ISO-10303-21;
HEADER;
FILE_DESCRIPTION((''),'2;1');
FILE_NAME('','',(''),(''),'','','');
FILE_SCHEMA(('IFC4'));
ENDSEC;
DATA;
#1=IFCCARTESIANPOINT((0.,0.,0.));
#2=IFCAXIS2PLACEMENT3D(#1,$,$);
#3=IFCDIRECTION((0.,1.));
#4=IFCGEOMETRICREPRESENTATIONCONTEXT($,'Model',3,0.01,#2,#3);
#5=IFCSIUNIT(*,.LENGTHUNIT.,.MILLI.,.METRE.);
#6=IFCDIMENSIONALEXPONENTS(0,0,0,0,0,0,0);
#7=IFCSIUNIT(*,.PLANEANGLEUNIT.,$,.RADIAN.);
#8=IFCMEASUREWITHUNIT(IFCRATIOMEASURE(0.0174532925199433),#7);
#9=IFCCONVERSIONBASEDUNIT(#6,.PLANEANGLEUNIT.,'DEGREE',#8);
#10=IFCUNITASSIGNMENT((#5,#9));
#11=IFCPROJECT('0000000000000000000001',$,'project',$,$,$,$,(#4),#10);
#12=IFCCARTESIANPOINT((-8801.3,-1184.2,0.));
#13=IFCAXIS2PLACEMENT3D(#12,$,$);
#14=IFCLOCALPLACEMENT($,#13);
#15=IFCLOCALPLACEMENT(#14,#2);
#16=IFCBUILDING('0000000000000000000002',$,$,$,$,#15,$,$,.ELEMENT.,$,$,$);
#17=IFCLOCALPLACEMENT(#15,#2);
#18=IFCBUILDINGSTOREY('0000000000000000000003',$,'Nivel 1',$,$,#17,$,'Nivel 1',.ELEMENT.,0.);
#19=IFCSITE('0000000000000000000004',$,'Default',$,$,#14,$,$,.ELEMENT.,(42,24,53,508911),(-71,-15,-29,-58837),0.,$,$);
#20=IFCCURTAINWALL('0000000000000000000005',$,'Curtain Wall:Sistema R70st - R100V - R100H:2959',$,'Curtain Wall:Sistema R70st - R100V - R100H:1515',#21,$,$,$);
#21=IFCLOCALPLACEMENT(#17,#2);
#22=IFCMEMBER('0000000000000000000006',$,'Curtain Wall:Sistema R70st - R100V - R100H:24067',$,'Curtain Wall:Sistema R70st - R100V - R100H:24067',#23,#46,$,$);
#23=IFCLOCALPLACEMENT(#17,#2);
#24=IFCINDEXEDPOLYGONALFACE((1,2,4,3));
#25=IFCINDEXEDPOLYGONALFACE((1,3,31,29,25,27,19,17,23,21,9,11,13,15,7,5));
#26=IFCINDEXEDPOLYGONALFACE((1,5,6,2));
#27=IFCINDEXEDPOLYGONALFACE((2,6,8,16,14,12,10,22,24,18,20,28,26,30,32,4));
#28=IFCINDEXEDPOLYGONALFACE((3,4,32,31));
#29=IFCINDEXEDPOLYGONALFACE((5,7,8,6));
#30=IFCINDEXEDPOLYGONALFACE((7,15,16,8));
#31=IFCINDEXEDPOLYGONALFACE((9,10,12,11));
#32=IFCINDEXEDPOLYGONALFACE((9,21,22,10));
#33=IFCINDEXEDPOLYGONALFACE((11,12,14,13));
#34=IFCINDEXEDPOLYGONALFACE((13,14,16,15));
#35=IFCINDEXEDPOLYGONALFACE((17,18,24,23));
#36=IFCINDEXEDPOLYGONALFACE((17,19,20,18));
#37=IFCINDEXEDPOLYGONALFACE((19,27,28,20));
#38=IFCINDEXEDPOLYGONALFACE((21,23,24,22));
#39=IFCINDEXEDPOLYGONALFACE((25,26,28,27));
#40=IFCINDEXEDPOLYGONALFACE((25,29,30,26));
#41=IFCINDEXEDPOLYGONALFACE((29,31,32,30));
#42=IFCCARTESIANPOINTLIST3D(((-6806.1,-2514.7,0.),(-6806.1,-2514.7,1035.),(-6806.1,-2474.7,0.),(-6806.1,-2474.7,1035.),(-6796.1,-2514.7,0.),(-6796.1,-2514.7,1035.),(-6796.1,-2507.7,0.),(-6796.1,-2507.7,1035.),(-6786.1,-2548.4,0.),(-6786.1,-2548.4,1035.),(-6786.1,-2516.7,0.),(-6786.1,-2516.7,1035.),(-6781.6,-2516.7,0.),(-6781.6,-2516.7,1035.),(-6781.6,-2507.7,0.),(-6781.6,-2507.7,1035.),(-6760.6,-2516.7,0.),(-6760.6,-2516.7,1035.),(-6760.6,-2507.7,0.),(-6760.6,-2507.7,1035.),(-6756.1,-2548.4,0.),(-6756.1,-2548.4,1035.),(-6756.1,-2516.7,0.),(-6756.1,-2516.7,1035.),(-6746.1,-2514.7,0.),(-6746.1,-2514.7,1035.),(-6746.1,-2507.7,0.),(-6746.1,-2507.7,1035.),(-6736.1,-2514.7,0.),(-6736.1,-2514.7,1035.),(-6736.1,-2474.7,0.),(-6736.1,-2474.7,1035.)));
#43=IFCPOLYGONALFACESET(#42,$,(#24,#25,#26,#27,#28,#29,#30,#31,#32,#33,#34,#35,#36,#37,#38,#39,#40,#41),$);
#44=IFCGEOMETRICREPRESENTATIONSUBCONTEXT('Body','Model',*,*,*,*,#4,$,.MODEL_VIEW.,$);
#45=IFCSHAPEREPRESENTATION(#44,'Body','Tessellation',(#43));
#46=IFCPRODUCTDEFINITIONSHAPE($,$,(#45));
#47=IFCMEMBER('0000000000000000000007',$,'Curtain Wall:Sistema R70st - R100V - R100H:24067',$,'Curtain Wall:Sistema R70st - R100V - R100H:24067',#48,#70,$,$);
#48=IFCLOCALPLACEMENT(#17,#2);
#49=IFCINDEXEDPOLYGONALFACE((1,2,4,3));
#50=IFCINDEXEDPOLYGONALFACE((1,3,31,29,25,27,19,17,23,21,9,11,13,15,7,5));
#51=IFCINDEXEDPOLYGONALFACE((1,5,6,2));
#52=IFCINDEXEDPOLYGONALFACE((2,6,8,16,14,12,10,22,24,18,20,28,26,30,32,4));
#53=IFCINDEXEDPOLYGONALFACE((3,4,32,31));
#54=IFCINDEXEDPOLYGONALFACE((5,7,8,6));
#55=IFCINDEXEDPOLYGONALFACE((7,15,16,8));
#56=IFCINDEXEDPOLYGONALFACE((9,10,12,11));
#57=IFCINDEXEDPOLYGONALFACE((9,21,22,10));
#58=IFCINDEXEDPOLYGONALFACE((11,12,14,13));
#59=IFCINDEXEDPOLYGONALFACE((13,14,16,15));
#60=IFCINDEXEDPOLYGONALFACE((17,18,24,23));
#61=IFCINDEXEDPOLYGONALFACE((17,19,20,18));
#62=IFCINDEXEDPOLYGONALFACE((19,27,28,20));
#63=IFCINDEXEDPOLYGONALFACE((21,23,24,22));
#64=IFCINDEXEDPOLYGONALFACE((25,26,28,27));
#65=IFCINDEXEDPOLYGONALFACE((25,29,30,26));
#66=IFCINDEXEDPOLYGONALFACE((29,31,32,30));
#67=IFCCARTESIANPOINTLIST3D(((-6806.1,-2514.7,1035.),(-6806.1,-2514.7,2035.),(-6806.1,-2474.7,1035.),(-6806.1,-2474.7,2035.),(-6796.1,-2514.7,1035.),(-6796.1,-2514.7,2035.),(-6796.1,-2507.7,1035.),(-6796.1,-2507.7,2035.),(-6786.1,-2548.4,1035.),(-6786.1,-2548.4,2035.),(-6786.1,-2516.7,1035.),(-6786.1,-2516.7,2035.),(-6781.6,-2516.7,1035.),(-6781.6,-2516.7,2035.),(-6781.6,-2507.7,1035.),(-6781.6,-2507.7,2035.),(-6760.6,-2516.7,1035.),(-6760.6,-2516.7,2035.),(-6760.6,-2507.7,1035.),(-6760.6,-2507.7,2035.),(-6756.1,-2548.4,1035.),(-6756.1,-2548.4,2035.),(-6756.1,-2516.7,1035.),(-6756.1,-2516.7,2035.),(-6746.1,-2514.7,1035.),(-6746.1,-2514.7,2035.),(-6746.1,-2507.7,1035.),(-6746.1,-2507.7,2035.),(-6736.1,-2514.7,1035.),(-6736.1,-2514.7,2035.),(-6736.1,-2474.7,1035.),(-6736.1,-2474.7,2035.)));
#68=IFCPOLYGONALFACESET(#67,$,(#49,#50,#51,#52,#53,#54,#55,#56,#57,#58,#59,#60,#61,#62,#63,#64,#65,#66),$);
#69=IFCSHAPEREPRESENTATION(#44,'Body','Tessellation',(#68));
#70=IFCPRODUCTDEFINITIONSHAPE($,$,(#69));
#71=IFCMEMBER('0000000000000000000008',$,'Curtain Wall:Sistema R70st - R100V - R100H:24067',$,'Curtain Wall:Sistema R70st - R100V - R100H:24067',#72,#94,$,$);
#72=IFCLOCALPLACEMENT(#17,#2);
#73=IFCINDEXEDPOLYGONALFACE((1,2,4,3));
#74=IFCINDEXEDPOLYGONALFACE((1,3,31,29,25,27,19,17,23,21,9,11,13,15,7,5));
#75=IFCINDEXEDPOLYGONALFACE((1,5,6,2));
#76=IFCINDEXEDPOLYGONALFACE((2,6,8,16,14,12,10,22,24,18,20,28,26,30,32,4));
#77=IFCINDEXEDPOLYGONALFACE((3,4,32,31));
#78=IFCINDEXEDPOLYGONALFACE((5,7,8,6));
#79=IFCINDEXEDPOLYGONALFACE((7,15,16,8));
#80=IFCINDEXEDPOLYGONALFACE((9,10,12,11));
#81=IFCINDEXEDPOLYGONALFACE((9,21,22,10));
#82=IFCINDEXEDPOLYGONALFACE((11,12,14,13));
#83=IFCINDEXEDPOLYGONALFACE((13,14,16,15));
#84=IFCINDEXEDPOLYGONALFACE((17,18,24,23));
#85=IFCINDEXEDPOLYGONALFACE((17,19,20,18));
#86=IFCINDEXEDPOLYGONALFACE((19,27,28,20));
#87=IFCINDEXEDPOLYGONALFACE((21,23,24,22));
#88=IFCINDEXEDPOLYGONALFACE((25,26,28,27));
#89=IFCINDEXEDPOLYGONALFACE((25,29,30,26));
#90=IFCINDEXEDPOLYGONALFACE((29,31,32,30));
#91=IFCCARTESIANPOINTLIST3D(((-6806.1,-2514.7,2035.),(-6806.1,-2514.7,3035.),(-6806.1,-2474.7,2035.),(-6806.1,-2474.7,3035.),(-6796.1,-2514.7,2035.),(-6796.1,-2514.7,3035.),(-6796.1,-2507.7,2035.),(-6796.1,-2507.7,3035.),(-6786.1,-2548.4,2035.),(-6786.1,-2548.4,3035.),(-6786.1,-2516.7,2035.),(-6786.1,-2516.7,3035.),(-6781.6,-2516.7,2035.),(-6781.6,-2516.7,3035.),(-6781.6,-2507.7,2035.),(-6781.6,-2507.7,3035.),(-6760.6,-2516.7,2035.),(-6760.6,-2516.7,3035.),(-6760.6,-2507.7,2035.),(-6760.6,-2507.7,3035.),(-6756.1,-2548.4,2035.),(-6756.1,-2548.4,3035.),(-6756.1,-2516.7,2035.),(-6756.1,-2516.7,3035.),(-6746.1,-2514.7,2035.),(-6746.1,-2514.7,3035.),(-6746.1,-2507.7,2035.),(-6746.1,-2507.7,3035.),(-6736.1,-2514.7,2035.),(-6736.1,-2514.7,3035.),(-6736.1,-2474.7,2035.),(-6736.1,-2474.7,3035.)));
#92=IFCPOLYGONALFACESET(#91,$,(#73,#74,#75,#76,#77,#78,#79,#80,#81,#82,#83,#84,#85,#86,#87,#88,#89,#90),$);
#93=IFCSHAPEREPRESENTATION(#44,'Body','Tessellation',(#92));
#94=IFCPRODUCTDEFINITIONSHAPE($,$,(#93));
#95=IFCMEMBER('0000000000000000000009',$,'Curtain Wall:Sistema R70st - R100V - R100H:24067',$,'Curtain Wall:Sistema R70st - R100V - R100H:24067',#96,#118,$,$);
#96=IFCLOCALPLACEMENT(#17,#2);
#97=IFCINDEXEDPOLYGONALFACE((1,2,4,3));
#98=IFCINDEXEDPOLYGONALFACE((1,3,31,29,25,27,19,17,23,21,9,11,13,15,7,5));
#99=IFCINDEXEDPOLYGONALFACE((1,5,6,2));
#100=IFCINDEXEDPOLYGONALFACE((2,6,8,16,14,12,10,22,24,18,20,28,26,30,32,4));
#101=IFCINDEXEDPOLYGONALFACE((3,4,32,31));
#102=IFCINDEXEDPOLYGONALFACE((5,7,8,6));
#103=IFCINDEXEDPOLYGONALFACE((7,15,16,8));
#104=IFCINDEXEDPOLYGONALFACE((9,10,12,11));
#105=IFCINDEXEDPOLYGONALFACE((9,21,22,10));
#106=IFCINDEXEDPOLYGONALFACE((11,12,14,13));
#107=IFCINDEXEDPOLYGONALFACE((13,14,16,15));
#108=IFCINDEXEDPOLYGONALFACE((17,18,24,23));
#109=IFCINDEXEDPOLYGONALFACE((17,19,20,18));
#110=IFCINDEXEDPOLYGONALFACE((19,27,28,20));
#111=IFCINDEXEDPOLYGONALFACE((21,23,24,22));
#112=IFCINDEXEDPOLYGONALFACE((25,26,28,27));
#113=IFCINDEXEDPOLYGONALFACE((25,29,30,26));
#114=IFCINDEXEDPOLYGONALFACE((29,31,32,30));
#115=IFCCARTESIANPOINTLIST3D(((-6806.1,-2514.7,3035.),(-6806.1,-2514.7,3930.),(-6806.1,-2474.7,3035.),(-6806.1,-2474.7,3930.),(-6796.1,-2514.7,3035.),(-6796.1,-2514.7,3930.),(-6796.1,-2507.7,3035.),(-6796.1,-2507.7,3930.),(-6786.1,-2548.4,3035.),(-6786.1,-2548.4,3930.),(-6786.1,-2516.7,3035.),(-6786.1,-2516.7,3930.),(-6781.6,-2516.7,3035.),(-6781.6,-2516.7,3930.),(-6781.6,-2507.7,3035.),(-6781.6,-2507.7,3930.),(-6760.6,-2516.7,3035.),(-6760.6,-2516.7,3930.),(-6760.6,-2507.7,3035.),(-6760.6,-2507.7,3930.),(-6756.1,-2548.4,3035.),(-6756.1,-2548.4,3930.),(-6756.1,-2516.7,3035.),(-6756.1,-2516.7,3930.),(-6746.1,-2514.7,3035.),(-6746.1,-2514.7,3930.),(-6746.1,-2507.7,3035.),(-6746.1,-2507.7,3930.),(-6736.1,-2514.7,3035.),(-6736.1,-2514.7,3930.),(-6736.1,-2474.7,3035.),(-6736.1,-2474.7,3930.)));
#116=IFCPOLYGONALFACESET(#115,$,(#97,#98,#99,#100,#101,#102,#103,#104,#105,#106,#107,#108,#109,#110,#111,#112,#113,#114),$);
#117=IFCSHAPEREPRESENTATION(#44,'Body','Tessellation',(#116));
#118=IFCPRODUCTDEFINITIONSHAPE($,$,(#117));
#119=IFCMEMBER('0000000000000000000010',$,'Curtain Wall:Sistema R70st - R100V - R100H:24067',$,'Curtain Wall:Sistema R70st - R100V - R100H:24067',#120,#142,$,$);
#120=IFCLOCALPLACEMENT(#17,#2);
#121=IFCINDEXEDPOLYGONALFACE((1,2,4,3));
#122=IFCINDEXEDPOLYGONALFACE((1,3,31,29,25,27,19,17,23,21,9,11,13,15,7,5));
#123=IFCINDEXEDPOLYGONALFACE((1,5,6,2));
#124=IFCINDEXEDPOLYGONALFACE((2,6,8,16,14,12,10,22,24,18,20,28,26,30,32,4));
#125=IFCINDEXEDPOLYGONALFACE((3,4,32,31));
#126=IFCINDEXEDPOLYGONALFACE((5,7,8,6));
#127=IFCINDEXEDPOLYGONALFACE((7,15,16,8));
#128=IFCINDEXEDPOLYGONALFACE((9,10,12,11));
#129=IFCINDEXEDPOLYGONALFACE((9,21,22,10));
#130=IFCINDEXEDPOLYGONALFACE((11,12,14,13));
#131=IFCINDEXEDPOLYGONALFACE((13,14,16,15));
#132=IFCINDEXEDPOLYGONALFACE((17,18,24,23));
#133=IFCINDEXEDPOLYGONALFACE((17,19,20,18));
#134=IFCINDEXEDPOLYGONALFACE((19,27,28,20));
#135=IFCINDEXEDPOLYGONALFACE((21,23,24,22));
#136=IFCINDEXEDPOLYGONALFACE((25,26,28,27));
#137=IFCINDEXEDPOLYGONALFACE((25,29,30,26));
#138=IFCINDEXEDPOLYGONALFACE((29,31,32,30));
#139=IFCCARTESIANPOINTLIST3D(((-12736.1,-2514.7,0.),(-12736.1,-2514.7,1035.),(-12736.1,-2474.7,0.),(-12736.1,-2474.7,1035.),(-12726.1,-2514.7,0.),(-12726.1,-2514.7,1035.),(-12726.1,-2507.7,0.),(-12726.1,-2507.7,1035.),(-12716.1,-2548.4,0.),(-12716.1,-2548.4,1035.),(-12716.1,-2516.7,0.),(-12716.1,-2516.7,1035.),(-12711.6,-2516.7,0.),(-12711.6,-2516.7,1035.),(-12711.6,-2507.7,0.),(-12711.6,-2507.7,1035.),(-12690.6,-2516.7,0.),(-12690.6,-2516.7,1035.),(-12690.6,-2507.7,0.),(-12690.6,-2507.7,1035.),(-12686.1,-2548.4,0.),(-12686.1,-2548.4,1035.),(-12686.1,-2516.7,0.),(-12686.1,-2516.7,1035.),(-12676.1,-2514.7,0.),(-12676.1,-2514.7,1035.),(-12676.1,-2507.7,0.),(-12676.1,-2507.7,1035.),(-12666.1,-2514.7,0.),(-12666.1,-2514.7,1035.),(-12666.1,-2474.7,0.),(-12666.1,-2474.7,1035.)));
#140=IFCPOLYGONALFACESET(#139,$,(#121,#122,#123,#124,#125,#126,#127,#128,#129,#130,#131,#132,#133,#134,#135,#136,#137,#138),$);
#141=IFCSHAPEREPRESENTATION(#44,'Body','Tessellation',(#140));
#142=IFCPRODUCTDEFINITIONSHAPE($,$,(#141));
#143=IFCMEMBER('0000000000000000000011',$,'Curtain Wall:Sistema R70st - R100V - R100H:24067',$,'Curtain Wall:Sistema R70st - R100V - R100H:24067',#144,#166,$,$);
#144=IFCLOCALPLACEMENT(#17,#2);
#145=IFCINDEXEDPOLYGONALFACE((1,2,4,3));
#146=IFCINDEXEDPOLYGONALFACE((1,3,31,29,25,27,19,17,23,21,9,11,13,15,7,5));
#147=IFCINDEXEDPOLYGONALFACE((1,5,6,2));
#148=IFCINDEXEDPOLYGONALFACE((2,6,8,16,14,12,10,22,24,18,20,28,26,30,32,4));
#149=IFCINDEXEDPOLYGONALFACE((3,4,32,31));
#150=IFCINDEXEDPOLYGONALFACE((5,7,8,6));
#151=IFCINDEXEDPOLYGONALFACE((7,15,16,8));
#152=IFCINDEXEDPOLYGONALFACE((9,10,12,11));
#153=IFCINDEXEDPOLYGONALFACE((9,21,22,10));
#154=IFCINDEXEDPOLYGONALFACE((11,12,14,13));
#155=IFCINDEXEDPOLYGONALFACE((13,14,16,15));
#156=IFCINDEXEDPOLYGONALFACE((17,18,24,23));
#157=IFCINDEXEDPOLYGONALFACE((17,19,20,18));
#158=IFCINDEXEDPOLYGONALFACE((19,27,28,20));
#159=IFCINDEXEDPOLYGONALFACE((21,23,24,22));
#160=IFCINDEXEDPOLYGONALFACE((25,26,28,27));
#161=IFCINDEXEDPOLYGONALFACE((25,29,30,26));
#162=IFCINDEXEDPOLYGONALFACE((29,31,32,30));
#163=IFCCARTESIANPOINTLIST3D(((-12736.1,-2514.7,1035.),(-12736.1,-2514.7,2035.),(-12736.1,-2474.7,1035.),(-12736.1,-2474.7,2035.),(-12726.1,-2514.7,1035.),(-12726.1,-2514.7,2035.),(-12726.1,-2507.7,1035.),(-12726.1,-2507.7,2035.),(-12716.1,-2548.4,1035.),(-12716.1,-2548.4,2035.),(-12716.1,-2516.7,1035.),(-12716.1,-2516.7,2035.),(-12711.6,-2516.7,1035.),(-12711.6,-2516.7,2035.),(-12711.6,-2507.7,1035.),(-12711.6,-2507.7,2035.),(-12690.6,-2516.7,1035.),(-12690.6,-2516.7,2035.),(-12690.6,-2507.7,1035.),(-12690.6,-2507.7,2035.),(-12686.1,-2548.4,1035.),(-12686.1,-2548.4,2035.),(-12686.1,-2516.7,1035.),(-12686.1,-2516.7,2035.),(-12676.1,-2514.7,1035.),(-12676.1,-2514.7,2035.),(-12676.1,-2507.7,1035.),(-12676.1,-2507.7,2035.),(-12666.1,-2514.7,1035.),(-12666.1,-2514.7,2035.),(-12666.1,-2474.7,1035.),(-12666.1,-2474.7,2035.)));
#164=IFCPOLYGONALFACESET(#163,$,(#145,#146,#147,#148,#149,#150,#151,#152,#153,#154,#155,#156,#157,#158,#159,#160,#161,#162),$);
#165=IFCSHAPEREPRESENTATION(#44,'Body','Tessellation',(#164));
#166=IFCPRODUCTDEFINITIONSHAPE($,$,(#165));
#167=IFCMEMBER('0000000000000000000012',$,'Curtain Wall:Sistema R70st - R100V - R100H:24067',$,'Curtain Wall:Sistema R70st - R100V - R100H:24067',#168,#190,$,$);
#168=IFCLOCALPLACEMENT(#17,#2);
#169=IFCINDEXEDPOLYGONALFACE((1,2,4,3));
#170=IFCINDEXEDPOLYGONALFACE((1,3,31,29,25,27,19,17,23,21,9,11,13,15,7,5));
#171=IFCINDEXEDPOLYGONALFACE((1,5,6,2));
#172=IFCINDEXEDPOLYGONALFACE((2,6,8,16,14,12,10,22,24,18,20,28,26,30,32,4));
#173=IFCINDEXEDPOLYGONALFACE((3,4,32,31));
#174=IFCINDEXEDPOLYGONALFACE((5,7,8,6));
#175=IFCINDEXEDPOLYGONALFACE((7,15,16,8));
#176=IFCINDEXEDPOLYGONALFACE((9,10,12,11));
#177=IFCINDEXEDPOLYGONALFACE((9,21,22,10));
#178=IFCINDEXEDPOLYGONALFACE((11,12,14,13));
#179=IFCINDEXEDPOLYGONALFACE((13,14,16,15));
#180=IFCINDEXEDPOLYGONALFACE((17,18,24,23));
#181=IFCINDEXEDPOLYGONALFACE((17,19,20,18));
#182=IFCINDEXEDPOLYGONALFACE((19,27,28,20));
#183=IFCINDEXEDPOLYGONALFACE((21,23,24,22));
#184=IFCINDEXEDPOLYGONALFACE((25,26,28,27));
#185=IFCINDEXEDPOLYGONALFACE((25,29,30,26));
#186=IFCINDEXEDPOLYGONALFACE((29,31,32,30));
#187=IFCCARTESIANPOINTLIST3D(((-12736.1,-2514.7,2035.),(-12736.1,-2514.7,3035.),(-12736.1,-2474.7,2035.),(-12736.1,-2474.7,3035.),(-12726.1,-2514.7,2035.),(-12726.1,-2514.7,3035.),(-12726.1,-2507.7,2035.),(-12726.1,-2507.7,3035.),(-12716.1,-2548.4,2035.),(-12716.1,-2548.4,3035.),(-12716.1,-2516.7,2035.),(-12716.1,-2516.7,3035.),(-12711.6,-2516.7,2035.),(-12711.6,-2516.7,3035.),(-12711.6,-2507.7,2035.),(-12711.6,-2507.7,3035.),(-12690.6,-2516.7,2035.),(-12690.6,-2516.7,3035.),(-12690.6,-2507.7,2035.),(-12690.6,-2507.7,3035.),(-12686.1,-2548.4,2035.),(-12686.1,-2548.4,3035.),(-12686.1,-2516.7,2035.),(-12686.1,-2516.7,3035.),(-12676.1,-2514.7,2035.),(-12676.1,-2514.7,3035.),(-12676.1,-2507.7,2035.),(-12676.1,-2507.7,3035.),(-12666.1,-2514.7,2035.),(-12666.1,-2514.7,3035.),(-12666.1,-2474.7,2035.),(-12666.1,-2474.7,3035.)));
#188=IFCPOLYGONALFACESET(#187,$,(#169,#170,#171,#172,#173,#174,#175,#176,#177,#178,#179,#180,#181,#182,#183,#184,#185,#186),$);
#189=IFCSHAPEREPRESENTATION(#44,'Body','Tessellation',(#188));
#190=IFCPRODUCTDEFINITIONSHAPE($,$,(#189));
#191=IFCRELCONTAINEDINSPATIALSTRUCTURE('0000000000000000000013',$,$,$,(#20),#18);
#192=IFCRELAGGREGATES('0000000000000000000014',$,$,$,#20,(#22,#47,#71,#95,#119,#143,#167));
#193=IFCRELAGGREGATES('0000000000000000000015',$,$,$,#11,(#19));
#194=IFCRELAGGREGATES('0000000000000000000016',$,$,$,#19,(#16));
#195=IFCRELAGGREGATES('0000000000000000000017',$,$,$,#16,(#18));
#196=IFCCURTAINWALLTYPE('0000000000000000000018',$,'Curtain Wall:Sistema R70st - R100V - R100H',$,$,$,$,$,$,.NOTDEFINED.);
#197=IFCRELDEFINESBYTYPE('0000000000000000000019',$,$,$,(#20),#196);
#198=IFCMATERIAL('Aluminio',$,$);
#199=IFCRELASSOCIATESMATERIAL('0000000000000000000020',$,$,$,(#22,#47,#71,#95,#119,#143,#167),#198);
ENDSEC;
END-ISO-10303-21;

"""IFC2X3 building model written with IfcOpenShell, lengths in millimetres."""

from ifc_helpers import new_model, entity, si_unit, converted_unit, direction, frame, origin, place, context, subcontext, project, spatial, polyline, outline, extrude, material, type_object, element, aggregate, save


model = new_model("IFC2X3")

# Units and contexts
model_context = context("Model", 3, precision=0.01, world=origin(), true_north=direction((0.0, 1.0)))
body_context = subcontext(model_context, "Body", "Model", "MODEL_VIEW")
ifc_project = project(units=[si_unit("LENGTHUNIT", "METRE", prefix="MILLI"), converted_unit("PLANEANGLEUNIT", "DEGREE", entity("IfcRatioMeasure", 0.0174532925199433), si_unit("PLANEANGLEUNIT", "RADIAN"), dimensions=[0, 0, 0, 0, 0, 0, 0])], contexts=[model_context])

# Site, building, storey
site_placement = place(None, frame((-8801.3, -1184.2, 0.0)))
site = spatial("IfcSite", under=ifc_project, at=site_placement, Name="Default", CompositionType="ELEMENT", RefLatitude=(42, 24, 53, 508911), RefLongitude=(-71, -15, -29, -58837), RefElevation=0.0)
building_placement = place(site_placement, origin())
building = spatial("IfcBuilding", under=site, at=building_placement, CompositionType="ELEMENT")
storey_placement = place(building_placement, origin())
storey = spatial("IfcBuildingStorey", under=building, at=storey_placement, Name="Nivel 1", LongName="Nivel 1", CompositionType="ELEMENT", Elevation=0.0)

# Curtain wall, members
curtain_wall_type = type_object("IfcCurtainWallType", Name="Curtain Wall:Sistema R70st - R100V - R100H", PredefinedType="NOTDEFINED")
curtain_wall_placement = place(storey_placement, origin())
curtain_wall = element("IfcCurtainWall", 1, at=curtain_wall_placement, inside=storey, type_object=curtain_wall_type, Name="Curtain Wall:Sistema R70st - R100V - R100H:2959", ObjectType="Curtain Wall:Sistema R70st - R100V - R100H:1515")
ifc_material = material(Name="Aluminio")
member_1_placement = place(curtain_wall_placement, origin())
member_1 = element("IfcMember", 2, at=member_1_placement, material=ifc_material, Name="Curtain Wall:Sistema R70st - R100V - R100H:24067", ObjectType="Curtain Wall:Sistema R70st - R100V - R100H:24067", context=body_context, shape_type="SweptSolid", body=[
    extrude(outline(polyline([(-35.0, -38.0), (35.0, -38.0), (35.0, 2.0), (25.0, 2.0), (25.0, -5.0), (10.5, -5.0), (10.5, 4.0), (15.0, 4.0), (15.0, 35.7), (-15.0, 35.7), (-15.0, 4.0), (-10.5, 4.0), (-10.5, -5.0), (-25.0, -5.0), (-25.0, 2.0), (-35.0, 2.0), (-35.0, -38.0)])), frame((-6771.1, -2512.7, 0.0), z_axis=(0.0, 0.0, 1.0), x_axis=(-1.0, 0.0, 0.0)), (0.0, 0.0, 1.0), 1035.0),
])
member_2_placement = place(curtain_wall_placement, origin())
member_2 = element("IfcMember", 3, at=member_2_placement, material=ifc_material, Name="Curtain Wall:Sistema R70st - R100V - R100H:24067", ObjectType="Curtain Wall:Sistema R70st - R100V - R100H:24067", context=body_context, shape_type="SweptSolid", body=[
    extrude(outline(polyline([(-35.0, -38.0), (35.0, -38.0), (35.0, 2.0), (25.0, 2.0), (25.0, -5.0), (10.5, -5.0), (10.5, 4.0), (15.0, 4.0), (15.0, 35.7), (-15.0, 35.7), (-15.0, 4.0), (-10.5, 4.0), (-10.5, -5.0), (-25.0, -5.0), (-25.0, 2.0), (-35.0, 2.0), (-35.0, -38.0)])), frame((-6771.1, -2512.7, 1035.0), z_axis=(0.0, 0.0, 1.0), x_axis=(-1.0, 0.0, 0.0)), (0.0, 0.0, 1.0), 1000.0),
])
member_3_placement = place(curtain_wall_placement, origin())
member_3 = element("IfcMember", 4, at=member_3_placement, material=ifc_material, Name="Curtain Wall:Sistema R70st - R100V - R100H:24067", ObjectType="Curtain Wall:Sistema R70st - R100V - R100H:24067", context=body_context, shape_type="SweptSolid", body=[
    extrude(outline(polyline([(-35.0, -38.0), (35.0, -38.0), (35.0, 2.0), (25.0, 2.0), (25.0, -5.0), (10.5, -5.0), (10.5, 4.0), (15.0, 4.0), (15.0, 35.7), (-15.0, 35.7), (-15.0, 4.0), (-10.5, 4.0), (-10.5, -5.0), (-25.0, -5.0), (-25.0, 2.0), (-35.0, 2.0), (-35.0, -38.0)])), frame((-6771.1, -2512.7, 2035.0), z_axis=(0.0, 0.0, 1.0), x_axis=(-1.0, 0.0, 0.0)), (0.0, 0.0, 1.0), 1000.0),
])
member_4_placement = place(curtain_wall_placement, origin())
member_4 = element("IfcMember", 5, at=member_4_placement, material=ifc_material, Name="Curtain Wall:Sistema R70st - R100V - R100H:24067", ObjectType="Curtain Wall:Sistema R70st - R100V - R100H:24067", context=body_context, shape_type="SweptSolid", body=[
    extrude(outline(polyline([(-35.0, -38.0), (35.0, -38.0), (35.0, 2.0), (25.0, 2.0), (25.0, -5.0), (10.5, -5.0), (10.5, 4.0), (15.0, 4.0), (15.0, 35.7), (-15.0, 35.7), (-15.0, 4.0), (-10.5, 4.0), (-10.5, -5.0), (-25.0, -5.0), (-25.0, 2.0), (-35.0, 2.0), (-35.0, -38.0)])), frame((-6771.1, -2512.7, 3035.0), z_axis=(0.0, 0.0, 1.0), x_axis=(-1.0, 0.0, 0.0)), (0.0, 0.0, 1.0), 895.0),
])
member_5_placement = place(curtain_wall_placement, origin())
member_5 = element("IfcMember", 6, at=member_5_placement, material=ifc_material, Name="Curtain Wall:Sistema R70st - R100V - R100H:24067", ObjectType="Curtain Wall:Sistema R70st - R100V - R100H:24067", context=body_context, shape_type="SweptSolid", body=[
    extrude(outline(polyline([(-15.0, -35.7), (15.0, -35.7), (15.0, -4.0), (10.5, -4.0), (10.5, 5.0), (25.0, 5.0), (25.0, -2.0), (35.0, -2.0), (35.0, 38.0), (-35.0, 38.0), (-35.0, -2.0), (-25.0, -2.0), (-25.0, 5.0), (-10.5, 5.0), (-10.5, -4.0), (-15.0, -4.0), (-15.0, -35.7)])), frame((-12701.1, -2512.7, 1035.0), z_axis=(0.0, 0.0, -1.0), x_axis=(-1.0, 0.0, 0.0)), (0.0, 0.0, 1.0), 1035.0),
])
member_6_placement = place(curtain_wall_placement, origin())
member_6 = element("IfcMember", 7, at=member_6_placement, material=ifc_material, Name="Curtain Wall:Sistema R70st - R100V - R100H:24067", ObjectType="Curtain Wall:Sistema R70st - R100V - R100H:24067", context=body_context, shape_type="SweptSolid", body=[
    extrude(outline(polyline([(-15.0, -35.7), (15.0, -35.7), (15.0, -4.0), (10.5, -4.0), (10.5, 5.0), (25.0, 5.0), (25.0, -2.0), (35.0, -2.0), (35.0, 38.0), (-35.0, 38.0), (-35.0, -2.0), (-25.0, -2.0), (-25.0, 5.0), (-10.5, 5.0), (-10.5, -4.0), (-15.0, -4.0), (-15.0, -35.7)])), frame((-12701.1, -2512.7, 2035.0), z_axis=(0.0, 0.0, -1.0), x_axis=(-1.0, 0.0, 0.0)), (0.0, 0.0, 1.0), 1000.0),
])
member_7_placement = place(curtain_wall_placement, origin())
member_7 = element("IfcMember", 8, at=member_7_placement, material=ifc_material, Name="Curtain Wall:Sistema R70st - R100V - R100H:24067", ObjectType="Curtain Wall:Sistema R70st - R100V - R100H:24067", context=body_context, shape_type="SweptSolid", body=[
    extrude(outline(polyline([(-15.0, -35.7), (15.0, -35.7), (15.0, -4.0), (10.5, -4.0), (10.5, 5.0), (25.0, 5.0), (25.0, -2.0), (35.0, -2.0), (35.0, 38.0), (-35.0, 38.0), (-35.0, -2.0), (-25.0, -2.0), (-25.0, 5.0), (-10.5, 5.0), (-10.5, -4.0), (-15.0, -4.0), (-15.0, -35.7)])), frame((-12701.1, -2512.7, 3035.0), z_axis=(0.0, 0.0, -1.0), x_axis=(-1.0, 0.0, 0.0)), (0.0, 0.0, 1.0), 1000.0),
])
aggregate(curtain_wall, [member_1, member_2, member_3, member_4, member_5, member_6, member_7])

save(model, "model.ifc")
